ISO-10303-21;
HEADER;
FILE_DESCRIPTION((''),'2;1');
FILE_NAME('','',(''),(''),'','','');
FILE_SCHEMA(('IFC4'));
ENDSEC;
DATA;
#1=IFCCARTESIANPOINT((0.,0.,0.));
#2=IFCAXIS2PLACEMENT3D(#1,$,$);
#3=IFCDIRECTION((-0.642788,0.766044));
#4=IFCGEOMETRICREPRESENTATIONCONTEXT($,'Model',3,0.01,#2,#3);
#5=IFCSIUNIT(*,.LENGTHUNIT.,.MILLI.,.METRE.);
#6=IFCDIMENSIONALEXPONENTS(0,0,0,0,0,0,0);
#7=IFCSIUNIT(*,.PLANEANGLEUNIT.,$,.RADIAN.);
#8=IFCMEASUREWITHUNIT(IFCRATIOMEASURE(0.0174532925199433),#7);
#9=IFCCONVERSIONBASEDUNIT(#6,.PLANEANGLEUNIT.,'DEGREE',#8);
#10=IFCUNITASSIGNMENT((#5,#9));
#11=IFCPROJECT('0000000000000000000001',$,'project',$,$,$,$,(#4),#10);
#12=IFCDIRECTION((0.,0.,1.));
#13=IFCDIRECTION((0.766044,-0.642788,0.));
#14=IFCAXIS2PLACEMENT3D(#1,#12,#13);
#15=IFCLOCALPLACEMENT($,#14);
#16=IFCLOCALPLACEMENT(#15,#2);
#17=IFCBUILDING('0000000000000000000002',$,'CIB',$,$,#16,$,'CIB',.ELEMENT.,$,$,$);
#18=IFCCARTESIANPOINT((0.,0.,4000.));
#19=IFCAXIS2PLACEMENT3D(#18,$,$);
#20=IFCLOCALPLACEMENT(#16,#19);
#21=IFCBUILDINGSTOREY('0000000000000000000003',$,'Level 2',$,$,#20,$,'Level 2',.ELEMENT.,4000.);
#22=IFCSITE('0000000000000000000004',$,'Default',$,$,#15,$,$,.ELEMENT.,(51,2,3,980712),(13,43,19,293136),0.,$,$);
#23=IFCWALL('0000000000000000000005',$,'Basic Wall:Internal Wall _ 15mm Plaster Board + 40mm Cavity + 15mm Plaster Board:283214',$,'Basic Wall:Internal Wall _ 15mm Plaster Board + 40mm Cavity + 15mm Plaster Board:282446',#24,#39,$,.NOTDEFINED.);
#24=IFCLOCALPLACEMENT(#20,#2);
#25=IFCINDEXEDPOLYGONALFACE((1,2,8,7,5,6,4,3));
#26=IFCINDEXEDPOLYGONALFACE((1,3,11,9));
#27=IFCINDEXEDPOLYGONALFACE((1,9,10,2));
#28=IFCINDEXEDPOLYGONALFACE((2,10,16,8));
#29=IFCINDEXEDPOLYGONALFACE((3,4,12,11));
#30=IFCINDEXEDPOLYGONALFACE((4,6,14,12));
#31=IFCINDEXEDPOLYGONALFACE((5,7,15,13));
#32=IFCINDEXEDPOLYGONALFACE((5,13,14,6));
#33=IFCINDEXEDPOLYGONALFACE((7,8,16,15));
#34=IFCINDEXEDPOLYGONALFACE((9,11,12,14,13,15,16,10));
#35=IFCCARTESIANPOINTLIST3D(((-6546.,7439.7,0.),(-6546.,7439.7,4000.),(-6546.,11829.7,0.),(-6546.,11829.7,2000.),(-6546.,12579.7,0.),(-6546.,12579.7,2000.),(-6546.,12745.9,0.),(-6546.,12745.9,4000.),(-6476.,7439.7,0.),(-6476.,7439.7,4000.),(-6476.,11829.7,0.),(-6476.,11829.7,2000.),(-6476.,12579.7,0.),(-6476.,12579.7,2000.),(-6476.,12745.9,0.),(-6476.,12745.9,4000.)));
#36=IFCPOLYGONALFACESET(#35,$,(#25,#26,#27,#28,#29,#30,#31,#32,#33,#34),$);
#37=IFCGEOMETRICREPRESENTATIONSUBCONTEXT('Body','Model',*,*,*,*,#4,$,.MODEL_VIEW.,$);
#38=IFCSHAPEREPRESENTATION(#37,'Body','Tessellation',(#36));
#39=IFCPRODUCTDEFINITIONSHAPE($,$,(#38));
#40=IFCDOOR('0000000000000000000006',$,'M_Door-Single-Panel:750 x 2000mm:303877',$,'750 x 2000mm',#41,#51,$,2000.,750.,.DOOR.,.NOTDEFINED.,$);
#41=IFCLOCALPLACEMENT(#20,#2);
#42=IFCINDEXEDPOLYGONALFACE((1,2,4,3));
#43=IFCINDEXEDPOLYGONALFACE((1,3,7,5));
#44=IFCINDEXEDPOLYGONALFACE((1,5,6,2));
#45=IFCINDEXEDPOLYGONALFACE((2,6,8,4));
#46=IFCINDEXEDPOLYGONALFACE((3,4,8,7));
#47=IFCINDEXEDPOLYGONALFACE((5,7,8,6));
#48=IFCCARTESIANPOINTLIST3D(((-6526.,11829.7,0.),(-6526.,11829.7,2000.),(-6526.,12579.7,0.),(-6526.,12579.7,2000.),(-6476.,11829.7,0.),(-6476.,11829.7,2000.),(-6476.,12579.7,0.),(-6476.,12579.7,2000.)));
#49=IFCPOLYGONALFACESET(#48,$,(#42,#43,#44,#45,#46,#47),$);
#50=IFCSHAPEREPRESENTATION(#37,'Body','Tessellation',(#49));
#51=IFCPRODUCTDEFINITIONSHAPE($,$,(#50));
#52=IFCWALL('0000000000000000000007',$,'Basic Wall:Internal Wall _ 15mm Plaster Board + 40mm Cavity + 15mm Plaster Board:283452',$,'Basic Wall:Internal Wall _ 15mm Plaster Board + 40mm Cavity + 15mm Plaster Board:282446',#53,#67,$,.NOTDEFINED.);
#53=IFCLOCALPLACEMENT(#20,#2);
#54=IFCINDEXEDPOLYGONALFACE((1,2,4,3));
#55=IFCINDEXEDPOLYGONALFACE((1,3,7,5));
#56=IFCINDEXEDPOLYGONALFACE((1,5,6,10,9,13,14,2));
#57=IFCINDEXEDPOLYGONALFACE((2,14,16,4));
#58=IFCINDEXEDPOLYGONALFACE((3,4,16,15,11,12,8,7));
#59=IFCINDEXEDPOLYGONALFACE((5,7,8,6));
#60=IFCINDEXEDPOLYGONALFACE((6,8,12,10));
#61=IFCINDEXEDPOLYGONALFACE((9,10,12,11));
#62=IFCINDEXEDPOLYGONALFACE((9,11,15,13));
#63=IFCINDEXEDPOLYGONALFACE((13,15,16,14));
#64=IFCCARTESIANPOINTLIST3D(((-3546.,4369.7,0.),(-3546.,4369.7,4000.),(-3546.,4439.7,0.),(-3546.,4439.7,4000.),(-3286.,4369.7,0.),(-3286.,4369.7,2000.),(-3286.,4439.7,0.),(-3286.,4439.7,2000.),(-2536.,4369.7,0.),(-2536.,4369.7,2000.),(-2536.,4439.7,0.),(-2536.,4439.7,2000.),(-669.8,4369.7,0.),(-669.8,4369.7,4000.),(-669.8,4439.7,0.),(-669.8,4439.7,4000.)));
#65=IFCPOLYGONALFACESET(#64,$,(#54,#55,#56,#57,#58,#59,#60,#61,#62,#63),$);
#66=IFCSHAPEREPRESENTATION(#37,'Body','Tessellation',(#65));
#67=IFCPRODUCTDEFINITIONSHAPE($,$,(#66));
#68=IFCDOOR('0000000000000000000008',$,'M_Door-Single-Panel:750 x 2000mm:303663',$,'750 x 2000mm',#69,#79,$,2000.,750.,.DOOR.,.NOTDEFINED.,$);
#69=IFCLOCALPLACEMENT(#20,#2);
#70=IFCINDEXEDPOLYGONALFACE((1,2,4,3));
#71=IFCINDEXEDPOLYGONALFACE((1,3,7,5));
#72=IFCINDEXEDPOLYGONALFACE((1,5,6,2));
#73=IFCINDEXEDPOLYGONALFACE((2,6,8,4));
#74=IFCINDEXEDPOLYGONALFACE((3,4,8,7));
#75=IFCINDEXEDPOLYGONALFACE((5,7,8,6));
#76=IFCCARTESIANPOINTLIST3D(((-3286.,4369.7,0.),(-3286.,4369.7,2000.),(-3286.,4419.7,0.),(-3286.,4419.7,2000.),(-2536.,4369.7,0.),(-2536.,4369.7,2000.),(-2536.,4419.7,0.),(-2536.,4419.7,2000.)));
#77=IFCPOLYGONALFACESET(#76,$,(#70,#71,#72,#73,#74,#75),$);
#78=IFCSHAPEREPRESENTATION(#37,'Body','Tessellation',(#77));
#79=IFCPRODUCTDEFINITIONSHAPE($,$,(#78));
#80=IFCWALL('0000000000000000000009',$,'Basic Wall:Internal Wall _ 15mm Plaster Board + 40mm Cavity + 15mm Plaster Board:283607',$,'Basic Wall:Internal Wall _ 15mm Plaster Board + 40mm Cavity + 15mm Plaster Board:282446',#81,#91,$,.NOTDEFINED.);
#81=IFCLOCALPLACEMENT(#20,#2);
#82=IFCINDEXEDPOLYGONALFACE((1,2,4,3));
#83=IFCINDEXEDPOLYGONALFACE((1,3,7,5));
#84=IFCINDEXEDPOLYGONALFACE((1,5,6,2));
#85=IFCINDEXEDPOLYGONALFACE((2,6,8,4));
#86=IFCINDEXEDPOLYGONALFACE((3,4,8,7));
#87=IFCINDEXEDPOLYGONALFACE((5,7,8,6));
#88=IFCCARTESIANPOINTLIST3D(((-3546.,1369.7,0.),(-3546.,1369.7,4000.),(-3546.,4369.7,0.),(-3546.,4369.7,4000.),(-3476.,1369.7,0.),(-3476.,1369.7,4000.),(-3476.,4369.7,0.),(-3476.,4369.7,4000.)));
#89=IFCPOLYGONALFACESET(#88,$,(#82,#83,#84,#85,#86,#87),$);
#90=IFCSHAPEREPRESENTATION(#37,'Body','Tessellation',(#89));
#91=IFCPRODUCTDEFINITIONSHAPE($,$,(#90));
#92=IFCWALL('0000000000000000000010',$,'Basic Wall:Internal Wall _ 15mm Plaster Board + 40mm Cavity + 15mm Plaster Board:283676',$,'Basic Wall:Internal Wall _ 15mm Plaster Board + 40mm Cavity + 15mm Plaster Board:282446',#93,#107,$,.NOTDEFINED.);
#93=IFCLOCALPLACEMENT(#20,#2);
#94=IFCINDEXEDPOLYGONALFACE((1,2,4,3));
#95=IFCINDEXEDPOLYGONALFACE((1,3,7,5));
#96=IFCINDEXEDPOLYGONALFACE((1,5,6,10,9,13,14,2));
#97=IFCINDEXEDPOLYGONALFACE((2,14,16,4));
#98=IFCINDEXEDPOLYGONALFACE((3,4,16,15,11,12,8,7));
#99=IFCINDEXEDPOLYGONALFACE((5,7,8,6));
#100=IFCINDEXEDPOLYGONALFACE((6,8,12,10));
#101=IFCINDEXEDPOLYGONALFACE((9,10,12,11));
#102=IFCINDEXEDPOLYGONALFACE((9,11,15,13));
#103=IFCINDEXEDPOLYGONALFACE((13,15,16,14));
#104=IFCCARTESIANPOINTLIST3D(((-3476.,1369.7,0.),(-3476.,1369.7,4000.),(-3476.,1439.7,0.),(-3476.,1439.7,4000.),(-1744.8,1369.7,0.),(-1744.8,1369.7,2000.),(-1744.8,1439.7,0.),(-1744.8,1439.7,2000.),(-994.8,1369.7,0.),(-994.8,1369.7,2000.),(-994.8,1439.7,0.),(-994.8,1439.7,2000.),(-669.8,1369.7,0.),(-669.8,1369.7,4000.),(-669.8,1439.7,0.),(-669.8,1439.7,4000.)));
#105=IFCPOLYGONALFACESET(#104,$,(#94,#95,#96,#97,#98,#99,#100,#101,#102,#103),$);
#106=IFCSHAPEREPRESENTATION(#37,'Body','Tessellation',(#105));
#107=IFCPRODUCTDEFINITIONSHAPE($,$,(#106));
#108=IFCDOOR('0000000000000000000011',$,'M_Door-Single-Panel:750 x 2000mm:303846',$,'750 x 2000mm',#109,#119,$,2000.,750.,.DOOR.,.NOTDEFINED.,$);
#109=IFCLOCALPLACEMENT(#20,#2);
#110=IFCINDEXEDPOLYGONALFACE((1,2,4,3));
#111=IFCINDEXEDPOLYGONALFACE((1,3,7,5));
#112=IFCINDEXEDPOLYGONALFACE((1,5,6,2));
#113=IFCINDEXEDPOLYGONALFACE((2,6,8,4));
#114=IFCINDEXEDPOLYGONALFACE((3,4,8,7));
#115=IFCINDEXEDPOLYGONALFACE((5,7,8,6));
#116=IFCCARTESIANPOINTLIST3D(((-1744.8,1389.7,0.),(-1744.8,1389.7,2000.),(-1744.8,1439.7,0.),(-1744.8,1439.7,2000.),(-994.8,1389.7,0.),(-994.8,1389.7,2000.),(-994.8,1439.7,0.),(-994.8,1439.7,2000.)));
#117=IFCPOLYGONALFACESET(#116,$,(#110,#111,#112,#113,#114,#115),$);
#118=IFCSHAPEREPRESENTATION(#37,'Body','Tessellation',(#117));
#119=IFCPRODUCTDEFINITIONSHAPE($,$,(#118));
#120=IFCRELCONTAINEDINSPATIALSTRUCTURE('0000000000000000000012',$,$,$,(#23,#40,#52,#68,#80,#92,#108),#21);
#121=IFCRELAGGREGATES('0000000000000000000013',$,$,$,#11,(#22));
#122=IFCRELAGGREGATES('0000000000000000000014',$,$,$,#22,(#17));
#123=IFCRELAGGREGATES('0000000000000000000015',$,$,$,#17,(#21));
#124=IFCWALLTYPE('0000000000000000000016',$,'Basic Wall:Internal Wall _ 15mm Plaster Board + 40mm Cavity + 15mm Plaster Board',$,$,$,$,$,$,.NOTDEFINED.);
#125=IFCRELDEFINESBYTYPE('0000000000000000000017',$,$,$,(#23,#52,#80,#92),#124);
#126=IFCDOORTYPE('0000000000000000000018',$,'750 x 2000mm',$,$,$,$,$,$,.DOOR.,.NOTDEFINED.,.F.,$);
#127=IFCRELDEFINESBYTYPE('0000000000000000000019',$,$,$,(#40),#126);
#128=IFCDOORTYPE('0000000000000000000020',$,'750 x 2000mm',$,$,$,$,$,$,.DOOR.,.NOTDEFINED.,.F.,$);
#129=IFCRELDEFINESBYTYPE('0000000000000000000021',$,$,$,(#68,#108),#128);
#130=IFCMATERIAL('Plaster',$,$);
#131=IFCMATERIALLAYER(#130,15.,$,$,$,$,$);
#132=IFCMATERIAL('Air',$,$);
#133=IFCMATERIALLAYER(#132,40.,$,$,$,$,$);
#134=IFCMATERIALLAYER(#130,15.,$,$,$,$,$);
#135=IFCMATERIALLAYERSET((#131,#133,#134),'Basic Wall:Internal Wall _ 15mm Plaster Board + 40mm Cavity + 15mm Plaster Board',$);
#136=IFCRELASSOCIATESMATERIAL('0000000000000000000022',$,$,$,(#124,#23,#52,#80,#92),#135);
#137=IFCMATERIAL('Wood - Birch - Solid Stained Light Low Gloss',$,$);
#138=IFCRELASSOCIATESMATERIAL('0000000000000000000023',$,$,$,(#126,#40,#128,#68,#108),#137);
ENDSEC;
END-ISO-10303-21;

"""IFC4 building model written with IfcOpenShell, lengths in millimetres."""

from ifc_helpers import new_model, entity, si_unit, converted_unit, direction, frame, frame_2d, origin, origin_2d_with_axis, place, context, subcontext, project, spatial, rectangle, extrude, source, transform, mapped, material, layer, layer_set, layer_usage, type_object, type_shapes, element, fill, save


model = new_model("IFC4")

# Units and contexts
model_context = context("Model", 3, precision=0.01, world=origin(), true_north=direction((-0.642788, 0.766044)))
body_context = subcontext(model_context, "Body", "Model", "MODEL_VIEW")
ifc_project = project(units=[si_unit("LENGTHUNIT", "METRE", prefix="MILLI"), converted_unit("PLANEANGLEUNIT", "DEGREE", entity("IfcRatioMeasure", 0.0174532925199433), si_unit("PLANEANGLEUNIT", "RADIAN"), dimensions=[0, 0, 0, 0, 0, 0, 0])], contexts=[model_context])

# Site, building, storey
site_placement = place(None, frame((0.0, 0.0, 0.0), z_axis=(0.0, 0.0, 1.0), x_axis=(0.766044, -0.642788, 0.0)))
site = spatial("IfcSite", under=ifc_project, at=site_placement, Name="Default", CompositionType="ELEMENT", RefLatitude=(51, 2, 3, 980712), RefLongitude=(13, 43, 19, 293136), RefElevation=0.0)
building_placement = place(site_placement, origin())
building = spatial("IfcBuilding", under=site, at=building_placement, Name="CIB", LongName="CIB", CompositionType="ELEMENT")
storey_placement = place(building_placement, frame((0.0, 0.0, 4000.0)))
storey = spatial("IfcBuildingStorey", under=building, at=storey_placement, Name="Level 2", LongName="Level 2", CompositionType="ELEMENT", Elevation=4000.0)

# Shared definitions
ifc_material_1 = material(Name="Plaster")

# Walls, openings, doors
ifc_layer_1 = layer(ifc_material_1, 15.0)
ifc_material_2 = material(Name="Air")
ifc_layer_2 = layer(ifc_material_2, 40.0)
ifc_layer_3 = layer(ifc_material_1, 15.0)
ifc_layer_set_1 = layer_set([ifc_layer_1, ifc_layer_2, ifc_layer_3], Name="Basic Wall:Internal Wall _ 15mm Plaster Board + 40mm Cavity + 15mm Plaster Board")
ifc_layer_usage_1 = layer_usage(ifc_layer_set_1, "AXIS2", "NEGATIVE", 35.0)
wall_type_1 = type_object("IfcWallType", Name="Basic Wall:Internal Wall _ 15mm Plaster Board + 40mm Cavity + 15mm Plaster Board", PredefinedType="NOTDEFINED", material=ifc_layer_set_1)
wall_1_placement = place(storey_placement, frame((-6511.0, 7439.7, 0.0), z_axis=(0.0, 0.0, 1.0), x_axis=(0.0, 1.0, 0.0)))
wall_1 = element("IfcWall", 1, at=wall_1_placement, inside=storey, type_object=wall_type_1, material=ifc_layer_usage_1, Name="Basic Wall:Internal Wall _ 15mm Plaster Board + 40mm Cavity + 15mm Plaster Board:283214", ObjectType="Basic Wall:Internal Wall _ 15mm Plaster Board + 40mm Cavity + 15mm Plaster Board:282446", PredefinedType="NOTDEFINED", context=body_context, shape_type="SweptSolid", body=[
    extrude(rectangle(XDim=5306.2, YDim=70.0, at=frame_2d((2653.1, 0.0), x_axis=(-1.0, 0.0))), origin(), (0.0, 0.0, 1.0), 4000.0),
])
opening_1_placement = place(wall_1_placement, frame((5140.0, 35.0, 0.0)))
opening_1 = element("IfcOpeningElement", 2, at=opening_1_placement, cuts=wall_1, ObjectType="Opening", PredefinedType="OPENING", context=body_context, shape_type="SweptSolid", body=[
    extrude(rectangle(XDim=750.0, YDim=2000.0, at=frame_2d((1000.0, 375.0), x_axis=(0.0, -1.0))), frame((0.0, 0.0, 0.0), z_axis=(0.0, -1.0, 0.0), x_axis=(0.0, 0.0, 1.0)), (0.0, 0.0, 1.0), 70.0),
])
ifc_material_3 = material(Name="Wood - Birch - Solid Stained Light Low Gloss")
door_type_1 = type_object("IfcDoorType", Name="750 x 2000mm", OperationType="NOTDEFINED", ParameterTakesPrecedence=False, PredefinedType="DOOR", material=ifc_material_3)
shared_shape_1 = source(origin(), body_context, "Body", "SweptSolid", [
    extrude(rectangle(XDim=750.0, YDim=50.0, at=origin_2d_with_axis()), frame((375.0, 45.0, 0.0)), (0.0, 0.0, 1.0), 2000.0),
])
type_shapes(door_type_1, [shared_shape_1])
door_1_placement = place(opening_1_placement, frame((0.0, 0.0, 0.0), z_axis=(0.0, 0.0, 1.0), x_axis=(-1.0, 0.0, 0.0)))
door_1 = element("IfcDoor", 3, at=door_1_placement, inside=storey, type_object=door_type_1, material=ifc_material_3, Name="M_Door-Single-Panel:750 x 2000mm:303877", ObjectType="750 x 2000mm", OperationType="NOTDEFINED", OverallHeight=2000.0, OverallWidth=750.0, PredefinedType="DOOR", context=body_context, shape_type="MappedRepresentation", body=[
    mapped(shared_shape_1, transform((0.0, 0.0, 0.0), scale=1.0)),
])
fill(opening_1, door_1)
ifc_layer_usage_2 = layer_usage(ifc_layer_set_1, "AXIS2", "NEGATIVE", 35.0)
wall_2_placement = place(storey_placement, frame((-669.8, 4404.7, 0.0), z_axis=(0.0, 0.0, 1.0), x_axis=(-1.0, 0.0, 0.0)))
wall_2 = element("IfcWall", 4, at=wall_2_placement, inside=storey, type_object=wall_type_1, material=ifc_layer_usage_2, Name="Basic Wall:Internal Wall _ 15mm Plaster Board + 40mm Cavity + 15mm Plaster Board:283452", ObjectType="Basic Wall:Internal Wall _ 15mm Plaster Board + 40mm Cavity + 15mm Plaster Board:282446", PredefinedType="NOTDEFINED", context=body_context, shape_type="SweptSolid", body=[
    extrude(rectangle(XDim=2876.2, YDim=70.0, at=frame_2d((1438.1, 0.0), x_axis=(-1.0, 0.0))), origin(), (0.0, 0.0, 1.0), 4000.0),
])
opening_2_placement = place(wall_2_placement, frame((1866.2, -35.0, 0.0)))
opening_2 = element("IfcOpeningElement", 5, at=opening_2_placement, cuts=wall_2, ObjectType="Opening", PredefinedType="OPENING", context=body_context, shape_type="SweptSolid", body=[
    extrude(rectangle(XDim=750.0, YDim=2000.0, at=frame_2d((1000.0, 375.0), x_axis=(0.0, 1.0))), frame((0.0, 0.0, 0.0), z_axis=(0.0, 1.0, 0.0), x_axis=(0.0, 0.0, 1.0)), (0.0, 0.0, 1.0), 70.0),
])
door_type_2 = type_object("IfcDoorType", Name="750 x 2000mm", OperationType="NOTDEFINED", ParameterTakesPrecedence=False, PredefinedType="DOOR", material=ifc_material_3)
shared_shape_2 = source(origin(), body_context, "Body", "SweptSolid", [
    extrude(rectangle(XDim=50.0, YDim=750.0, at=origin_2d_with_axis()), frame((375.0, 45.0, 0.0), z_axis=(0.0, 0.0, 1.0), x_axis=(0.0, 1.0, 0.0)), (0.0, 0.0, 1.0), 2000.0),
])
type_shapes(door_type_2, [shared_shape_2])
door_2_placement = place(opening_2_placement, origin())
door_2 = element("IfcDoor", 6, at=door_2_placement, inside=storey, type_object=door_type_2, material=ifc_material_3, Name="M_Door-Single-Panel:750 x 2000mm:303663", ObjectType="750 x 2000mm", OperationType="NOTDEFINED", OverallHeight=2000.0, OverallWidth=750.0, PredefinedType="DOOR", context=body_context, shape_type="MappedRepresentation", body=[
    mapped(shared_shape_2, transform((0.0, 0.0, 0.0), scale=1.0)),
])
fill(opening_2, door_2)

# Wall
ifc_layer_usage_3 = layer_usage(ifc_layer_set_1, "AXIS2", "NEGATIVE", 35.0)
wall_3_placement = place(storey_placement, frame((-3511.0, 4369.7, 0.0), z_axis=(0.0, 0.0, 1.0), x_axis=(0.0, -1.0, 0.0)))
element("IfcWall", 7, at=wall_3_placement, inside=storey, type_object=wall_type_1, material=ifc_layer_usage_3, Name="Basic Wall:Internal Wall _ 15mm Plaster Board + 40mm Cavity + 15mm Plaster Board:283607", ObjectType="Basic Wall:Internal Wall _ 15mm Plaster Board + 40mm Cavity + 15mm Plaster Board:282446", PredefinedType="NOTDEFINED", context=body_context, shape_type="SweptSolid", body=[
    extrude(rectangle(XDim=3000.0, YDim=70.0, at=frame_2d((1500.0, 0.0), x_axis=(-1.0, 0.0))), origin(), (0.0, 0.0, 1.0), 4000.0),
])

# Wall, opening, door
ifc_layer_usage_4 = layer_usage(ifc_layer_set_1, "AXIS2", "NEGATIVE", 35.0)
wall_4_placement = place(storey_placement, frame((-3476.0, 1404.7, 0.0)))
wall_4 = element("IfcWall", 8, at=wall_4_placement, inside=storey, type_object=wall_type_1, material=ifc_layer_usage_4, Name="Basic Wall:Internal Wall _ 15mm Plaster Board + 40mm Cavity + 15mm Plaster Board:283676", ObjectType="Basic Wall:Internal Wall _ 15mm Plaster Board + 40mm Cavity + 15mm Plaster Board:282446", PredefinedType="NOTDEFINED", context=body_context, shape_type="SweptSolid", body=[
    extrude(rectangle(XDim=2806.3, YDim=70.0, at=frame_2d((1403.1, 0.0), x_axis=(-1.0, 0.0))), origin(), (0.0, 0.0, 1.0), 4000.0),
])
opening_3_placement = place(wall_4_placement, frame((1731.3, -35.0, 0.0)))
opening_3 = element("IfcOpeningElement", 9, at=opening_3_placement, cuts=wall_4, ObjectType="Opening", PredefinedType="OPENING", context=body_context, shape_type="SweptSolid", body=[
    extrude(rectangle(XDim=750.0, YDim=2000.0, at=frame_2d((1000.0, 375.0), x_axis=(0.0, 1.0))), frame((0.0, 0.0, 0.0), z_axis=(0.0, 1.0, 0.0), x_axis=(0.0, 0.0, 1.0)), (0.0, 0.0, 1.0), 70.0),
])
door_3_placement = place(opening_3_placement, origin())
door_3 = element("IfcDoor", 10, at=door_3_placement, inside=storey, type_object=door_type_2, material=ifc_material_3, Name="M_Door-Single-Panel:750 x 2000mm:303846", ObjectType="750 x 2000mm", OperationType="NOTDEFINED", OverallHeight=2000.0, OverallWidth=750.0, PredefinedType="DOOR", context=body_context, shape_type="MappedRepresentation", body=[
    mapped(shared_shape_2, transform((0.0, 0.0, 0.0), scale=1.0)),
])
fill(opening_3, door_3)

save(model, "model.ifc")
